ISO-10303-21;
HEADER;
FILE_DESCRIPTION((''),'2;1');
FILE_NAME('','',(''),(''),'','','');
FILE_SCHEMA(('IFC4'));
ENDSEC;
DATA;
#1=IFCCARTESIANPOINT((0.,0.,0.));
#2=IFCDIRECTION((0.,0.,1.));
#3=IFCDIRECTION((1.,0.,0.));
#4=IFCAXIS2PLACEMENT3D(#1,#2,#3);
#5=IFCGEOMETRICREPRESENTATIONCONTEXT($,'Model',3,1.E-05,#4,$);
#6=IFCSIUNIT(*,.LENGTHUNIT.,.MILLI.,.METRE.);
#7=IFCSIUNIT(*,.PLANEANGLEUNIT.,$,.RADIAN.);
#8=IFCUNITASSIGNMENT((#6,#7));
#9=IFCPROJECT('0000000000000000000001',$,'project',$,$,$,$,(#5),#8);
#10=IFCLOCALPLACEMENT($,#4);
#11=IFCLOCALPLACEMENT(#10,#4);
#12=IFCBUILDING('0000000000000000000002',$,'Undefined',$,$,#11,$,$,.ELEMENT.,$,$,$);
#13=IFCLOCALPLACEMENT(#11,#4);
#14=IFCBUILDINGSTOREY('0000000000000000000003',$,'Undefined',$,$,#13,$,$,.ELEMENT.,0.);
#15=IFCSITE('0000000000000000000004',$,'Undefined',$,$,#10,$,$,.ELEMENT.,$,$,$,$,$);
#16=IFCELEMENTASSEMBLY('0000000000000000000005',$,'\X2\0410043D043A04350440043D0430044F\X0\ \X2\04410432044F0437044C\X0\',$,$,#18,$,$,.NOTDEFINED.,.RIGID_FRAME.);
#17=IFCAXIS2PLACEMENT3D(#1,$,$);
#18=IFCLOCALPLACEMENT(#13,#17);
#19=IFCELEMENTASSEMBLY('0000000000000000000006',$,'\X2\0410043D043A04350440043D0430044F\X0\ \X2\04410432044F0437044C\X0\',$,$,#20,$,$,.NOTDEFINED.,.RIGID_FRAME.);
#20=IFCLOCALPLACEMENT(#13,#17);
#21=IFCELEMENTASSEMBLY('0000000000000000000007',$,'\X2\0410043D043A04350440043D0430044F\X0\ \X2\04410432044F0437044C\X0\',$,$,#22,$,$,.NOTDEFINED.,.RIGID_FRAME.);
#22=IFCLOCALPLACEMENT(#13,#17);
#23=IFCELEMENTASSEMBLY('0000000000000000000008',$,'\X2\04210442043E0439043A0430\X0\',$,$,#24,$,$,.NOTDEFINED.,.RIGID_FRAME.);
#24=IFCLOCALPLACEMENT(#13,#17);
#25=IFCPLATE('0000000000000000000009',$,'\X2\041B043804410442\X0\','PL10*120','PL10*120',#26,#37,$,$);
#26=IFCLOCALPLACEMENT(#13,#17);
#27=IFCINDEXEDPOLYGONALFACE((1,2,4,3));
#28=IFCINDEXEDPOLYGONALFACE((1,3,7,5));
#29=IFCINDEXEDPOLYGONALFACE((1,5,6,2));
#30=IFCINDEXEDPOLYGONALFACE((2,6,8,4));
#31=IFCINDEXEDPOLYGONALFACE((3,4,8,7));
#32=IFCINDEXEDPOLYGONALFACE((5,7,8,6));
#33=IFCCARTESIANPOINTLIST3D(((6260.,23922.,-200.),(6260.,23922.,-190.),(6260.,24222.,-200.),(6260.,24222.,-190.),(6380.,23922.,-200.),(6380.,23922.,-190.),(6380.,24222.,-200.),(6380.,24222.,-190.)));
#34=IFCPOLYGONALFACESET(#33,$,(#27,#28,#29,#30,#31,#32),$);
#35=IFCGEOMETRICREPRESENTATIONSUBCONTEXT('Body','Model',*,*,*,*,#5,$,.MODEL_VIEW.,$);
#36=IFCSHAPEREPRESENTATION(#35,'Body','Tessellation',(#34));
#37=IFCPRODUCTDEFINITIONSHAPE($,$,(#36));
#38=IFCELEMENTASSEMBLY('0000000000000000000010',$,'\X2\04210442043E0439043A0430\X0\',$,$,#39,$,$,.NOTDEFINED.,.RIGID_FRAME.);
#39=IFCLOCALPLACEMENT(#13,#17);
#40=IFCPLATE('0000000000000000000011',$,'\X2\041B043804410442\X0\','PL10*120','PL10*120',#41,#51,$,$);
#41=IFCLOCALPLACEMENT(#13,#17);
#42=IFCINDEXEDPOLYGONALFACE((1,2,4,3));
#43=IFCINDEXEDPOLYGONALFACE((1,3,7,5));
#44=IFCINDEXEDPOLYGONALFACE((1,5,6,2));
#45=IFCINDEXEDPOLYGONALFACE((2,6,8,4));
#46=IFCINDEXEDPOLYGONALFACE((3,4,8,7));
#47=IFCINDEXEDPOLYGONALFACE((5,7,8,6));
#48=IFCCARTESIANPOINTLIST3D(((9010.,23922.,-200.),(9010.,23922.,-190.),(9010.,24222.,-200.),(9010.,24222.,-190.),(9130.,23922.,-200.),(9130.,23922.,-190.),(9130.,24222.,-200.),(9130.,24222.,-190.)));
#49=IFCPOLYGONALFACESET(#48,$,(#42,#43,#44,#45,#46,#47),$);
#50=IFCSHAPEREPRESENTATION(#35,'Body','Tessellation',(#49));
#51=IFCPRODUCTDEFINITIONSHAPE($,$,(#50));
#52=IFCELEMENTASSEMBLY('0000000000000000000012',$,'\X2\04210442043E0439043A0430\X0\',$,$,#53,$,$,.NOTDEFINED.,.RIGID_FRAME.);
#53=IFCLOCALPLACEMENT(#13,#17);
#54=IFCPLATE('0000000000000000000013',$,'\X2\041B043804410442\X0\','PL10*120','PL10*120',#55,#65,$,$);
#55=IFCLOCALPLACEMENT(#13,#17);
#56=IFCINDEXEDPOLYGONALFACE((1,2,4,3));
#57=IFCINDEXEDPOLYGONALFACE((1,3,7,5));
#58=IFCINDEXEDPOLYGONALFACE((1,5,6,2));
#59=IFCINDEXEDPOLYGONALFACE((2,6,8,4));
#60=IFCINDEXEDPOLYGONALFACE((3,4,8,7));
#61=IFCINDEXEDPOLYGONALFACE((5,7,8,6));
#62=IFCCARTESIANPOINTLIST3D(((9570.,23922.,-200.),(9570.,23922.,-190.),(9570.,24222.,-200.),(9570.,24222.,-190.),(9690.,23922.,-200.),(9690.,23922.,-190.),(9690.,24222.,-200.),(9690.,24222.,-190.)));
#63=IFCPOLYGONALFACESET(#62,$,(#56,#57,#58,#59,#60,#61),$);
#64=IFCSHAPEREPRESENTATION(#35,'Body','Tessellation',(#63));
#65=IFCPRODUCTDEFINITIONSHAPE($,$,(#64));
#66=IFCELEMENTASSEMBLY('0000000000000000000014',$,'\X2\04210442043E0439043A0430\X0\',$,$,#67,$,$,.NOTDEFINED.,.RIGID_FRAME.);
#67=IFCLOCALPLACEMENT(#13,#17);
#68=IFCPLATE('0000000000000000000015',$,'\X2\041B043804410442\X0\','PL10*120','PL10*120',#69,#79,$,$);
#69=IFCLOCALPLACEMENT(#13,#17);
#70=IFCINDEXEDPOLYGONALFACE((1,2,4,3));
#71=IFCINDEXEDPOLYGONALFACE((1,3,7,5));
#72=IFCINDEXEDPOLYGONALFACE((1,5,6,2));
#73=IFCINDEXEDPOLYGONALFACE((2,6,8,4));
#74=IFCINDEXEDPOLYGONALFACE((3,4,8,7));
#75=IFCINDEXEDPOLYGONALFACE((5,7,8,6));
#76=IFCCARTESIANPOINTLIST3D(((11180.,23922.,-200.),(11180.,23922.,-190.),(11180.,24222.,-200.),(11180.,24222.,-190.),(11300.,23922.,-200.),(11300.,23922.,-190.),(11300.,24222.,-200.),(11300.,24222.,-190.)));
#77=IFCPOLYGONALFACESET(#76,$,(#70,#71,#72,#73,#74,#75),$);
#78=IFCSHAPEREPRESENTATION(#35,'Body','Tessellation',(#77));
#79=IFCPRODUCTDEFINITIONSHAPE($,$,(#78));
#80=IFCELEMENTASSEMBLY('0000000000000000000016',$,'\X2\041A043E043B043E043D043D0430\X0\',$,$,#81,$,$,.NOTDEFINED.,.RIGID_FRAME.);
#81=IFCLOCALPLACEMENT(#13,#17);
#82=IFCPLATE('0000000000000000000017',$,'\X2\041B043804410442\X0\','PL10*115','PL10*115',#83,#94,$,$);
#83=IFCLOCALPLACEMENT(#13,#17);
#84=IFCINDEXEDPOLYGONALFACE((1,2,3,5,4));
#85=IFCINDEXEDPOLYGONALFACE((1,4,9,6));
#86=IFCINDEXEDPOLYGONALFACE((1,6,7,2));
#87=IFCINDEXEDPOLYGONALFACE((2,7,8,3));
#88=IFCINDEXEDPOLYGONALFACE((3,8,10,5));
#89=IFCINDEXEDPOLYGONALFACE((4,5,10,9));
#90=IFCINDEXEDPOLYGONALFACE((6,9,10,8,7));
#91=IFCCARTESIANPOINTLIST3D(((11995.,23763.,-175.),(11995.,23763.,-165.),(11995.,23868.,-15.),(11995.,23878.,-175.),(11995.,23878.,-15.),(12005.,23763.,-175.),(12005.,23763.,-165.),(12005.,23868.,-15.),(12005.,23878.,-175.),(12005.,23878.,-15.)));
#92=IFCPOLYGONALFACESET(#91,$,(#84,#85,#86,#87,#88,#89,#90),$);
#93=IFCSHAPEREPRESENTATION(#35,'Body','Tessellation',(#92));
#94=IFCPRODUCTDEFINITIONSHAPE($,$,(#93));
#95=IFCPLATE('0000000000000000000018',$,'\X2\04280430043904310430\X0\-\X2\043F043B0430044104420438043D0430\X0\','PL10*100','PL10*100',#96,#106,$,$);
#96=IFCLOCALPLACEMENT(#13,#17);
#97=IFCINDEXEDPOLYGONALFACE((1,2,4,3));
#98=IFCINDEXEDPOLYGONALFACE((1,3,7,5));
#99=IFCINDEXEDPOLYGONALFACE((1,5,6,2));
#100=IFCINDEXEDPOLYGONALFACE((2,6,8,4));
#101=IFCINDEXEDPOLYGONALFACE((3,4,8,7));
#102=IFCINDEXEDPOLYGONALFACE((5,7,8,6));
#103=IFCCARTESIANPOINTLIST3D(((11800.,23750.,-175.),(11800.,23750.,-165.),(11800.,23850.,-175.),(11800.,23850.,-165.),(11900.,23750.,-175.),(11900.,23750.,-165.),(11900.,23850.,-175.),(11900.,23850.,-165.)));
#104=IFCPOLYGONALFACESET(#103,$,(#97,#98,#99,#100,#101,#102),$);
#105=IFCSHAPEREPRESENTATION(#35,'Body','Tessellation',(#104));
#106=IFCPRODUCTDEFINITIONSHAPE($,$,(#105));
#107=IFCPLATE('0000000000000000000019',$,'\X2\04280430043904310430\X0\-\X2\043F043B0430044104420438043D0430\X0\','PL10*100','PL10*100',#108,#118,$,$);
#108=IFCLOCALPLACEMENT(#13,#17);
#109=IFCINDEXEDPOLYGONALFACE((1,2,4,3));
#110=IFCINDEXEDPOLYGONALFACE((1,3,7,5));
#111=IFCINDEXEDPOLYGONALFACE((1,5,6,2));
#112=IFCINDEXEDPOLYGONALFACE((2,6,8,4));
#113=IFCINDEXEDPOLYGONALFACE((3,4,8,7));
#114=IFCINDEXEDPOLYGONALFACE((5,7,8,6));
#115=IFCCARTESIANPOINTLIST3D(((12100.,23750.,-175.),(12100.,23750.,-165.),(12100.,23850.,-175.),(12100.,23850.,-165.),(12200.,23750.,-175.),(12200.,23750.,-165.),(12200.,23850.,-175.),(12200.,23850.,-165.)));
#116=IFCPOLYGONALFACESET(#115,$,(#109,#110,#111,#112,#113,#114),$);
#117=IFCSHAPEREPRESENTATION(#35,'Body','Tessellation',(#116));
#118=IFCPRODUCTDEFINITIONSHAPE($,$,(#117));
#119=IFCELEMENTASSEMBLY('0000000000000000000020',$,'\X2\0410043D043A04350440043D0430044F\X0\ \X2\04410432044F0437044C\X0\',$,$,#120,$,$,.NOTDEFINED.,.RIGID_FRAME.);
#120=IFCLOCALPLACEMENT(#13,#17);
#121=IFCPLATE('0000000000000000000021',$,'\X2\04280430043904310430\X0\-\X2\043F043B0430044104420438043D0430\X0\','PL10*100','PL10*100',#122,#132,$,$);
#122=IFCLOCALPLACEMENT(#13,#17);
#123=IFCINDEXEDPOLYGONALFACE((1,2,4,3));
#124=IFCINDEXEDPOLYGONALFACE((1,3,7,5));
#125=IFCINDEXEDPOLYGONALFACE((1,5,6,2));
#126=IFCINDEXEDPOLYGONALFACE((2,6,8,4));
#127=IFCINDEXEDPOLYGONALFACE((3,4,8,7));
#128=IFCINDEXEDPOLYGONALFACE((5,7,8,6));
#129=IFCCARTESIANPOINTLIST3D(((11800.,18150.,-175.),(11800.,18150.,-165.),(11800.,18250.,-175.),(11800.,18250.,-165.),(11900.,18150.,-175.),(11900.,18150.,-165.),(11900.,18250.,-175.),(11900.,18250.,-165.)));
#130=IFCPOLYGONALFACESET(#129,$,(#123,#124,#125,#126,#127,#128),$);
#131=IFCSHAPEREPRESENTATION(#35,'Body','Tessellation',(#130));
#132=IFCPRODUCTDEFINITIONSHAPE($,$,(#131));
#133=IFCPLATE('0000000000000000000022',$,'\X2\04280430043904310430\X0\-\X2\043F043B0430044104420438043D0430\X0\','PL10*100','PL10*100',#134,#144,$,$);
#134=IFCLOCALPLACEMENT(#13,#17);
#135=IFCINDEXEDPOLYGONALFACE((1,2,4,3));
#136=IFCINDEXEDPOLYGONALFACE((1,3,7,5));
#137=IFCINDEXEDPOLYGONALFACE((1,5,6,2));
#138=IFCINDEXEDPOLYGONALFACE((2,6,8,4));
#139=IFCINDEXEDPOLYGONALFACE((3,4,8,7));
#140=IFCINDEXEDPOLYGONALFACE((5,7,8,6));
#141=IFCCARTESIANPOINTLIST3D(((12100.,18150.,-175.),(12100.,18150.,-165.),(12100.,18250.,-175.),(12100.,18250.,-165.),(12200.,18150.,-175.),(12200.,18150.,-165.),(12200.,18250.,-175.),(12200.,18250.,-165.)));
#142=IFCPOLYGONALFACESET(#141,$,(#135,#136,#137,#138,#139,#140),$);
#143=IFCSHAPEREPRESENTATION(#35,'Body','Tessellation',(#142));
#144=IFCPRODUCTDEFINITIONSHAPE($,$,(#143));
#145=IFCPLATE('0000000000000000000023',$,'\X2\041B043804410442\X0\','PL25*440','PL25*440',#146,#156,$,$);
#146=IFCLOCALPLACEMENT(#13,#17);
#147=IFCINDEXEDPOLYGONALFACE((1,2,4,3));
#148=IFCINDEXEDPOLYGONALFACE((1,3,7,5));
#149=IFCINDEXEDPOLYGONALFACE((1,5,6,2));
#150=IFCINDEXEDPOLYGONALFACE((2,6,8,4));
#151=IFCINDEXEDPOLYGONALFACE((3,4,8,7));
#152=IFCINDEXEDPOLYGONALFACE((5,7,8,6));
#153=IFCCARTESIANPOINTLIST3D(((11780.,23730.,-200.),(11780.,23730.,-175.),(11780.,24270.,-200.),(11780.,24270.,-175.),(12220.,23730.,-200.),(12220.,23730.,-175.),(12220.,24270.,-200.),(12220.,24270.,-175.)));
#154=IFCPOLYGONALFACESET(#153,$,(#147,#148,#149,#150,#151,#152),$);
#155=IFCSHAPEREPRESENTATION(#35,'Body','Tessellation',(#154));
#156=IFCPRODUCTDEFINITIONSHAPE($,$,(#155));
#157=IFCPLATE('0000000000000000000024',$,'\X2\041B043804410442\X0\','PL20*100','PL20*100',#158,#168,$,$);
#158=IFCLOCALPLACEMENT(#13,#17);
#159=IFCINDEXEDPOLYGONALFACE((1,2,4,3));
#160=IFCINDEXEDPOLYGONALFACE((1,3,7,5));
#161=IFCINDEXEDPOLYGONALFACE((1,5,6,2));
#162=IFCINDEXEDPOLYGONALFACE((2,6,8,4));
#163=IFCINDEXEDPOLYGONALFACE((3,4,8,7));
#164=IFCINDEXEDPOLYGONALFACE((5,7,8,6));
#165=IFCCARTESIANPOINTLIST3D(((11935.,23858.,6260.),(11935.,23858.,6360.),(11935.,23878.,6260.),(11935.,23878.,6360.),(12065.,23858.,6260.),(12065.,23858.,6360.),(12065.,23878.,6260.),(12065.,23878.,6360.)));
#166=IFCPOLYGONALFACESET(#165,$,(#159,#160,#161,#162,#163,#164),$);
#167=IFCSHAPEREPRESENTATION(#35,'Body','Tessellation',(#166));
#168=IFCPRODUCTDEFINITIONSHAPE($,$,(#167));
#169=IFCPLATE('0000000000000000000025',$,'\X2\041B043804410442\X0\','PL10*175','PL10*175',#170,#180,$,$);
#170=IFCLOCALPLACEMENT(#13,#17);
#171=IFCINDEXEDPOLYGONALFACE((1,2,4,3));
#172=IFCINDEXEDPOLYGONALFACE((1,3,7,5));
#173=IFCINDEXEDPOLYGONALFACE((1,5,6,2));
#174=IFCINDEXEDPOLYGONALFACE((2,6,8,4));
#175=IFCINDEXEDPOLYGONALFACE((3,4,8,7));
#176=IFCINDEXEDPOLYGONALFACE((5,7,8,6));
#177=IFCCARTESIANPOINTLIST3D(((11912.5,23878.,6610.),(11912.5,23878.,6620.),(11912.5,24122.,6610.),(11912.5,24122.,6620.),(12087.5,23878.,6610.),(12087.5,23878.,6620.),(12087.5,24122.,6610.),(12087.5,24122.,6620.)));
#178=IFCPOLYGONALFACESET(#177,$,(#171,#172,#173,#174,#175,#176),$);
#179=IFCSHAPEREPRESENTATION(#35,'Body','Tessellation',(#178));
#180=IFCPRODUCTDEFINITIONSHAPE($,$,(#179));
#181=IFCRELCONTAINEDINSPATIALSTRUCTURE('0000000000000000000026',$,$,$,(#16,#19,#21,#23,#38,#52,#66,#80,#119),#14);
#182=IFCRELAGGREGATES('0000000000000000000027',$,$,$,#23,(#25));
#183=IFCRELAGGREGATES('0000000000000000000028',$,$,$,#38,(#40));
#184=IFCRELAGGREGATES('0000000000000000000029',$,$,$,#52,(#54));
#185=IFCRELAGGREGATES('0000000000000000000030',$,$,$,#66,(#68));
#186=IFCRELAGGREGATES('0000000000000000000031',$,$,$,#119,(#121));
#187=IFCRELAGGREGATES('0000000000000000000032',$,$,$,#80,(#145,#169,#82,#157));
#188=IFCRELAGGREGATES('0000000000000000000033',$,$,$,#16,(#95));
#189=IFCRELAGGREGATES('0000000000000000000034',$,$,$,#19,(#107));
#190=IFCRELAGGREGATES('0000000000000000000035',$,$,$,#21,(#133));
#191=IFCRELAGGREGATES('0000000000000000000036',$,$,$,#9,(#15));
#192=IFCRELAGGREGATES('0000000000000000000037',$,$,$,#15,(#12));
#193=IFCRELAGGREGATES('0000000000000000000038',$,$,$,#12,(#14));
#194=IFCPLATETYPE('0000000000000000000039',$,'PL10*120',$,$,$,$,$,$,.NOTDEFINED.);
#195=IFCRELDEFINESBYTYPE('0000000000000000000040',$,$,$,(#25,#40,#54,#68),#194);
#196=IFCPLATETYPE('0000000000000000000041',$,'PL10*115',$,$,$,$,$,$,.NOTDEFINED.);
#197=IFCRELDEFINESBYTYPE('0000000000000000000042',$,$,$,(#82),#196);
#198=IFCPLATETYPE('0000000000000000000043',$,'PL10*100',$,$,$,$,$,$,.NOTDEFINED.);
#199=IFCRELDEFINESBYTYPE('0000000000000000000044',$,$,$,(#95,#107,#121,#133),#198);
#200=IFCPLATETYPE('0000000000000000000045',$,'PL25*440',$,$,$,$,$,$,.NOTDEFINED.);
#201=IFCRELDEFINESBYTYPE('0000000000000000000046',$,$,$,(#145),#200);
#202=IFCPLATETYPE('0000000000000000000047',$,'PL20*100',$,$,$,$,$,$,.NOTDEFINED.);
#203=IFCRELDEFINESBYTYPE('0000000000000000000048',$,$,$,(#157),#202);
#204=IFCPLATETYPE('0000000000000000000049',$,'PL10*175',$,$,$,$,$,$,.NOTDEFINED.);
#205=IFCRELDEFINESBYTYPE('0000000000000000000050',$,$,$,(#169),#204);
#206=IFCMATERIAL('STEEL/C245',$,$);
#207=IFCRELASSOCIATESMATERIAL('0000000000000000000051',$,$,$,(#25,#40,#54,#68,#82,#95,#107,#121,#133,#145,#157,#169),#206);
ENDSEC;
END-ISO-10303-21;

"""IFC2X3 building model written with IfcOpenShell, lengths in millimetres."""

from ifc_helpers import new_model, si_unit, frame, origin_with_axes, place, context, subcontext, project, spatial, polyline, outline, extrude, material, type_object, element, aggregate, save


model = new_model("IFC2X3")

# Units and contexts
model_context = context("Model", 3, precision=1e-05, world=origin_with_axes())
body_context = subcontext(model_context, "Body", "Model", "MODEL_VIEW")
ifc_project = project(units=[si_unit("LENGTHUNIT", "METRE", prefix="MILLI"), si_unit("PLANEANGLEUNIT", "RADIAN")], contexts=[model_context])

# Site, building, storey
site_placement = place(None, origin_with_axes())
site = spatial("IfcSite", under=ifc_project, at=site_placement, Name="Undefined", CompositionType="ELEMENT")
building_placement = place(site_placement, origin_with_axes())
building = spatial("IfcBuilding", under=site, at=building_placement, Name="Undefined", CompositionType="ELEMENT")
storey_placement = place(building_placement, origin_with_axes())
storey = spatial("IfcBuildingStorey", under=building, at=storey_placement, Name="Undefined", CompositionType="ELEMENT", Elevation=0.0)

# Shared definitions
ifc_material_1 = material(Name="STEEL/C245")

# Element assemblies
assembly_1_placement = place(storey_placement, origin_with_axes())
assembly_1 = element("IfcElementAssembly", 1, at=assembly_1_placement, inside=storey, Name="Анкерная связь", AssemblyPlace="NOTDEFINED", PredefinedType="RIGID_FRAME")
assembly_2_placement = place(storey_placement, origin_with_axes())
assembly_2 = element("IfcElementAssembly", 2, at=assembly_2_placement, inside=storey, Name="Анкерная связь", AssemblyPlace="NOTDEFINED", PredefinedType="RIGID_FRAME")
assembly_3_placement = place(storey_placement, origin_with_axes())
assembly_3 = element("IfcElementAssembly", 3, at=assembly_3_placement, inside=storey, Name="Анкерная связь", AssemblyPlace="NOTDEFINED", PredefinedType="RIGID_FRAME")

# Element assemblies, plates
assembly_4_placement = place(storey_placement, origin_with_axes())
assembly_4 = element("IfcElementAssembly", 4, at=assembly_4_placement, inside=storey, Name="Стойка", AssemblyPlace="NOTDEFINED", PredefinedType="RIGID_FRAME")
plate_type_1 = type_object("IfcPlateType", Name="PL10*120", PredefinedType="NOTDEFINED")
plate_1_placement = place(assembly_4_placement, frame((6320.0, 23922.0, -195.0), z_axis=(0.0, 0.0, 1.0), x_axis=(0.0, 1.0, 0.0)))
plate_1 = element("IfcPlate", 5, at=plate_1_placement, type_object=plate_type_1, material=ifc_material_1, Name="Лист", Description="PL10*120", ObjectType="PL10*120", context=body_context, shape_type="SweptSolid", body=[
    extrude(outline(polyline([(0.0, 60.0), (300.0, 60.0), (300.0, -60.0), (0.0, -60.0), (0.0, 60.0)])), frame((0.0, 0.0, -5.0), z_axis=(0.0, 0.0, 1.0), x_axis=(1.0, 0.0, 0.0)), (0.0, 0.0, 1.0), 10.0),
])
aggregate(assembly_4, [plate_1])
assembly_5_placement = place(storey_placement, origin_with_axes())
assembly_5 = element("IfcElementAssembly", 6, at=assembly_5_placement, inside=storey, Name="Стойка", AssemblyPlace="NOTDEFINED", PredefinedType="RIGID_FRAME")
plate_2_placement = place(assembly_5_placement, frame((9070.0, 23922.0, -195.0), z_axis=(0.0, 0.0, 1.0), x_axis=(0.0, 1.0, 0.0)))
plate_2 = element("IfcPlate", 7, at=plate_2_placement, type_object=plate_type_1, material=ifc_material_1, Name="Лист", Description="PL10*120", ObjectType="PL10*120", context=body_context, shape_type="SweptSolid", body=[
    extrude(outline(polyline([(0.0, 60.0), (300.0, 60.0), (300.0, -60.0), (0.0, -60.0), (0.0, 60.0)])), frame((0.0, 0.0, -5.0), z_axis=(0.0, 0.0, 1.0), x_axis=(1.0, 0.0, 0.0)), (0.0, 0.0, 1.0), 10.0),
])
aggregate(assembly_5, [plate_2])
assembly_6_placement = place(storey_placement, origin_with_axes())
assembly_6 = element("IfcElementAssembly", 8, at=assembly_6_placement, inside=storey, Name="Стойка", AssemblyPlace="NOTDEFINED", PredefinedType="RIGID_FRAME")
plate_3_placement = place(assembly_6_placement, frame((9630.0, 23922.0, -195.0), z_axis=(0.0, 0.0, 1.0), x_axis=(0.0, 1.0, 0.0)))
plate_3 = element("IfcPlate", 9, at=plate_3_placement, type_object=plate_type_1, material=ifc_material_1, Name="Лист", Description="PL10*120", ObjectType="PL10*120", context=body_context, shape_type="SweptSolid", body=[
    extrude(outline(polyline([(0.0, 60.0), (300.0, 60.0), (300.0, -60.0), (0.0, -60.0), (0.0, 60.0)])), frame((0.0, 0.0, -5.0), z_axis=(0.0, 0.0, 1.0), x_axis=(1.0, 0.0, 0.0)), (0.0, 0.0, 1.0), 10.0),
])
aggregate(assembly_6, [plate_3])
assembly_7_placement = place(storey_placement, origin_with_axes())
assembly_7 = element("IfcElementAssembly", 10, at=assembly_7_placement, inside=storey, Name="Стойка", AssemblyPlace="NOTDEFINED", PredefinedType="RIGID_FRAME")
plate_4_placement = place(assembly_7_placement, frame((11240.0, 23922.0, -195.0), z_axis=(0.0, 0.0, 1.0), x_axis=(0.0, 1.0, 0.0)))
plate_4 = element("IfcPlate", 11, at=plate_4_placement, type_object=plate_type_1, material=ifc_material_1, Name="Лист", Description="PL10*120", ObjectType="PL10*120", context=body_context, shape_type="SweptSolid", body=[
    extrude(outline(polyline([(0.0, 60.0), (300.0, 60.0), (300.0, -60.0), (0.0, -60.0), (0.0, 60.0)])), frame((0.0, 0.0, -5.0), z_axis=(0.0, 0.0, 1.0), x_axis=(1.0, 0.0, 0.0)), (0.0, 0.0, 1.0), 10.0),
])
aggregate(assembly_7, [plate_4])
assembly_8_placement = place(storey_placement, origin_with_axes())
assembly_8 = element("IfcElementAssembly", 12, at=assembly_8_placement, inside=storey, Name="Колонна", AssemblyPlace="NOTDEFINED", PredefinedType="RIGID_FRAME")
plate_type_2 = type_object("IfcPlateType", Name="PL10*115", PredefinedType="NOTDEFINED")
plate_5_placement = place(assembly_8_placement, frame((12000.0, 23878.0, -15.0), z_axis=(-1.0, 0.0, 0.0), x_axis=(0.0, 0.0, -1.0)))
plate_5 = element("IfcPlate", 13, at=plate_5_placement, type_object=plate_type_2, material=ifc_material_1, Name="Лист", Description="PL10*115", ObjectType="PL10*115", context=body_context, shape_type="SweptSolid", body=[
    extrude(outline(polyline([(0.0, 0.0), (160.0, 0.0), (160.0, 115.0), (150.0, 115.0), (0.0, 10.0), (0.0, 0.0)])), frame((0.0, 0.0, -5.0), z_axis=(0.0, 0.0, 1.0), x_axis=(1.0, 0.0, 0.0)), (0.0, 0.0, 1.0), 10.0),
])

# Plates
plate_type_3 = type_object("IfcPlateType", Name="PL10*100", PredefinedType="NOTDEFINED")
plate_6_placement = place(assembly_1_placement, frame((11900.0, 23850.0, -170.0), z_axis=(0.0, 0.0, -1.0), x_axis=(0.0, -1.0, 0.0)))
plate_6 = element("IfcPlate", 14, at=plate_6_placement, type_object=plate_type_3, material=ifc_material_1, Name="Шайба-пластина", Description="PL10*100", ObjectType="PL10*100", context=body_context, shape_type="SweptSolid", body=[
    extrude(outline(polyline([(0.0, 0.0), (100.0, 0.0), (100.0, 100.0), (0.0, 100.0), (0.0, 0.0)])), frame((0.0, 0.0, -5.0), z_axis=(0.0, 0.0, 1.0), x_axis=(1.0, 0.0, 0.0)), (0.0, 0.0, 1.0), 10.0),
])
plate_7_placement = place(assembly_2_placement, frame((12200.0, 23850.0, -170.0), z_axis=(0.0, 0.0, -1.0), x_axis=(0.0, -1.0, 0.0)))
plate_7 = element("IfcPlate", 15, at=plate_7_placement, type_object=plate_type_3, material=ifc_material_1, Name="Шайба-пластина", Description="PL10*100", ObjectType="PL10*100", context=body_context, shape_type="SweptSolid", body=[
    extrude(outline(polyline([(0.0, 0.0), (100.0, 0.0), (100.0, 100.0), (0.0, 100.0), (0.0, 0.0)])), frame((0.0, 0.0, -5.0), z_axis=(0.0, 0.0, 1.0), x_axis=(1.0, 0.0, 0.0)), (0.0, 0.0, 1.0), 10.0),
])

# Element assembly, plate
assembly_9_placement = place(storey_placement, origin_with_axes())
assembly_9 = element("IfcElementAssembly", 16, at=assembly_9_placement, inside=storey, Name="Анкерная связь", AssemblyPlace="NOTDEFINED", PredefinedType="RIGID_FRAME")
plate_8_placement = place(assembly_9_placement, frame((11900.0, 18250.0, -170.0), z_axis=(0.0, 0.0, -1.0), x_axis=(0.0, -1.0, 0.0)))
plate_8 = element("IfcPlate", 17, at=plate_8_placement, type_object=plate_type_3, material=ifc_material_1, Name="Шайба-пластина", Description="PL10*100", ObjectType="PL10*100", context=body_context, shape_type="SweptSolid", body=[
    extrude(outline(polyline([(0.0, 0.0), (100.0, 0.0), (100.0, 100.0), (0.0, 100.0), (0.0, 0.0)])), frame((0.0, 0.0, -5.0), z_axis=(0.0, 0.0, 1.0), x_axis=(1.0, 0.0, 0.0)), (0.0, 0.0, 1.0), 10.0),
])
aggregate(assembly_9, [plate_8])

# Plates
plate_9_placement = place(assembly_3_placement, frame((12200.0, 18250.0, -170.0), z_axis=(0.0, 0.0, -1.0), x_axis=(0.0, -1.0, 0.0)))
plate_9 = element("IfcPlate", 18, at=plate_9_placement, type_object=plate_type_3, material=ifc_material_1, Name="Шайба-пластина", Description="PL10*100", ObjectType="PL10*100", context=body_context, shape_type="SweptSolid", body=[
    extrude(outline(polyline([(0.0, 0.0), (100.0, 0.0), (100.0, 100.0), (0.0, 100.0), (0.0, 0.0)])), frame((0.0, 0.0, -5.0), z_axis=(0.0, 0.0, 1.0), x_axis=(1.0, 0.0, 0.0)), (0.0, 0.0, 1.0), 10.0),
])
plate_type_4 = type_object("IfcPlateType", Name="PL25*440", PredefinedType="NOTDEFINED")
plate_10_placement = place(assembly_8_placement, frame((12000.0, 23730.0, -187.5), z_axis=(0.0, 0.0, 1.0), x_axis=(0.0, 1.0, 0.0)))
plate_10 = element("IfcPlate", 19, at=plate_10_placement, type_object=plate_type_4, material=ifc_material_1, Name="Лист", Description="PL25*440", ObjectType="PL25*440", context=body_context, shape_type="SweptSolid", body=[
    extrude(outline(polyline([(0.0, 220.0), (540.0, 220.0), (540.0, -220.0), (0.0, -220.0), (0.0, 220.0)])), frame((0.0, 0.0, -12.5), z_axis=(0.0, 0.0, 1.0), x_axis=(1.0, 0.0, 0.0)), (0.0, 0.0, 1.0), 25.0),
])
plate_type_5 = type_object("IfcPlateType", Name="PL20*100", PredefinedType="NOTDEFINED")
plate_11_placement = place(assembly_8_placement, frame((12065.0, 23868.0, 6360.0), z_axis=(0.0, -1.0, 0.0), x_axis=(-1.0, 0.0, 0.0)))
plate_11 = element("IfcPlate", 20, at=plate_11_placement, type_object=plate_type_5, material=ifc_material_1, Name="Лист", Description="PL20*100", ObjectType="PL20*100", context=body_context, shape_type="SweptSolid", body=[
    extrude(outline(polyline([(0.0, 0.0), (130.0, 0.0), (130.0, 100.0), (0.0, 100.0), (0.0, 0.0)])), frame((0.0, 0.0, -10.0), z_axis=(0.0, 0.0, 1.0), x_axis=(1.0, 0.0, 0.0)), (0.0, 0.0, 1.0), 20.0),
])
plate_type_6 = type_object("IfcPlateType", Name="PL10*175", PredefinedType="NOTDEFINED")
plate_12_placement = place(assembly_8_placement, frame((11912.5, 23878.0, 6615.0), z_axis=(0.0, 0.0, -1.0), x_axis=(0.0, 1.0, 0.0)))
plate_12 = element("IfcPlate", 21, at=plate_12_placement, type_object=plate_type_6, material=ifc_material_1, Name="Лист", Description="PL10*175", ObjectType="PL10*175", context=body_context, shape_type="SweptSolid", body=[
    extrude(outline(polyline([(0.0, 0.0), (244.0, 0.0), (244.0, 175.0), (0.0, 175.0), (0.0, 0.0)])), frame((0.0, 0.0, -5.0), z_axis=(0.0, 0.0, 1.0), x_axis=(1.0, 0.0, 0.0)), (0.0, 0.0, 1.0), 10.0),
])
aggregate(assembly_8, [plate_10, plate_12, plate_5, plate_11])

aggregate(assembly_1, [plate_6])
aggregate(assembly_2, [plate_7])
aggregate(assembly_3, [plate_9])

save(model, "model.ifc")
